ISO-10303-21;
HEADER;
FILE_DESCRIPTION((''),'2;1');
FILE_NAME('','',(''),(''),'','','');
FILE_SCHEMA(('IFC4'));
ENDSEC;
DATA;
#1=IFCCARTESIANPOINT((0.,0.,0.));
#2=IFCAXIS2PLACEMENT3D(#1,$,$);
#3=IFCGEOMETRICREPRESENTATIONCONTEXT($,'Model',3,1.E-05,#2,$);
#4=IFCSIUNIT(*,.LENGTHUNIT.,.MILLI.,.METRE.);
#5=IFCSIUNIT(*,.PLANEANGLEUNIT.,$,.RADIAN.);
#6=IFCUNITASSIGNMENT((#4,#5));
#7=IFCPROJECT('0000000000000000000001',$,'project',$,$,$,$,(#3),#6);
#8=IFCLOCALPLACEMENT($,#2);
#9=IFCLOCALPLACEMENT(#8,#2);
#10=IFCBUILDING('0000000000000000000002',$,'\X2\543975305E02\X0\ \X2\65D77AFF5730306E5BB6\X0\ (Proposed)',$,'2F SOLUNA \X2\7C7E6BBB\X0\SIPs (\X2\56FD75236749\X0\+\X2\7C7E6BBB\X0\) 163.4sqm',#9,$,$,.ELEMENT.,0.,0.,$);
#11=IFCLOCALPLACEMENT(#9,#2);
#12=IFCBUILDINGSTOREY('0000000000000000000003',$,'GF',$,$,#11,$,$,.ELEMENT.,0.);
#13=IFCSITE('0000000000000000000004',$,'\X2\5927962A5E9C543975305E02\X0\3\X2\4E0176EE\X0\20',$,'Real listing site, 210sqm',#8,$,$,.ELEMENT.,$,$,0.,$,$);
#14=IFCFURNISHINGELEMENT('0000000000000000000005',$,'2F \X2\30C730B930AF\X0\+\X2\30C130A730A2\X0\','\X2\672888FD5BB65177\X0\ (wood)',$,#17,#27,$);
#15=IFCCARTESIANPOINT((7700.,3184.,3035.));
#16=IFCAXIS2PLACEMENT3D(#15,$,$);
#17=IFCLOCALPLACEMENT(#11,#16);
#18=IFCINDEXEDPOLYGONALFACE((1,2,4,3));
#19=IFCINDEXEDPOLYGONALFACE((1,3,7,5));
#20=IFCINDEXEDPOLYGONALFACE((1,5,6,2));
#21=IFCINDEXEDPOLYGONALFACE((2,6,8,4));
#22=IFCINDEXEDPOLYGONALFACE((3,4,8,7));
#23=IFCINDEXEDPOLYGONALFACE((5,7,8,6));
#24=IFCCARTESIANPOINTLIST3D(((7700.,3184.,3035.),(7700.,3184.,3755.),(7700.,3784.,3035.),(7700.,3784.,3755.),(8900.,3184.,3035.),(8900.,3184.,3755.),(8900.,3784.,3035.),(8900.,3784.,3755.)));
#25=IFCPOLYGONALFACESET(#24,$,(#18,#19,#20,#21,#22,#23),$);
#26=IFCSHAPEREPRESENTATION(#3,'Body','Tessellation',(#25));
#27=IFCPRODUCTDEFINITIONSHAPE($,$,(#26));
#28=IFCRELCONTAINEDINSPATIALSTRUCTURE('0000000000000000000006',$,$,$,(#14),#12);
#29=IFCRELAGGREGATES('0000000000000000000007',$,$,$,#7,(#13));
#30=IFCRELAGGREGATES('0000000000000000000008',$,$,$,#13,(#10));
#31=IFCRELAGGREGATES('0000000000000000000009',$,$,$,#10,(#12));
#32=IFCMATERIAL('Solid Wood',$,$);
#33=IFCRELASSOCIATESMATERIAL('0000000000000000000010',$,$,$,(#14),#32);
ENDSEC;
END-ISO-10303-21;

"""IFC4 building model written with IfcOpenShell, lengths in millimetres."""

from ifc_helpers import new_model, si_unit, frame, frame_2d, origin, place, context, project, spatial, rectangle, extrude, material, element, save


model = new_model("IFC4")

# Units and contexts
model_context = context("Model", 3, precision=1e-05, world=origin())
ifc_project = project(units=[si_unit("LENGTHUNIT", "METRE", prefix="MILLI"), si_unit("PLANEANGLEUNIT", "RADIAN")], contexts=[model_context])

# Site, building, storey
site_placement = place(None, origin())
site = spatial("IfcSite", under=ifc_project, at=site_placement, Name="大阪府吹田市3丁目20", ObjectType="Real listing site, 210sqm", CompositionType="ELEMENT", RefElevation=0.0)
building_placement = place(site_placement, origin())
building = spatial("IfcBuilding", under=site, at=building_placement, Name="吹田市 旗竿地の家 (Proposed)", ObjectType="2F SOLUNA 籾殻SIPs (国産杉+籾殻) 163.4sqm", CompositionType="ELEMENT", ElevationOfRefHeight=0.0, ElevationOfTerrain=0.0)
storey_placement = place(building_placement, origin())
storey = spatial("IfcBuildingStorey", under=building, at=storey_placement, Name="GF", CompositionType="ELEMENT", Elevation=0.0)

# Shared definitions
ifc_material_1 = material(Name="Solid Wood")

# Furnishing element
furnishing_1_placement = place(storey_placement, frame((7700.0, 3184.0, 3035.0)))
element("IfcFurnishingElement", 1, at=furnishing_1_placement, inside=storey, material=ifc_material_1, Name="2F デスク+チェア", Description="木製家具 (wood)", context=model_context, shape_type="SweptSolid", body=[
    extrude(rectangle(XDim=1200.0, YDim=600.0, at=frame_2d((600.0, 300.0))), frame((7700.0, 3184.0, 3035.0)), (0.0, 0.0, 1.0), 720.0),
])

save(model, "model.ifc")
